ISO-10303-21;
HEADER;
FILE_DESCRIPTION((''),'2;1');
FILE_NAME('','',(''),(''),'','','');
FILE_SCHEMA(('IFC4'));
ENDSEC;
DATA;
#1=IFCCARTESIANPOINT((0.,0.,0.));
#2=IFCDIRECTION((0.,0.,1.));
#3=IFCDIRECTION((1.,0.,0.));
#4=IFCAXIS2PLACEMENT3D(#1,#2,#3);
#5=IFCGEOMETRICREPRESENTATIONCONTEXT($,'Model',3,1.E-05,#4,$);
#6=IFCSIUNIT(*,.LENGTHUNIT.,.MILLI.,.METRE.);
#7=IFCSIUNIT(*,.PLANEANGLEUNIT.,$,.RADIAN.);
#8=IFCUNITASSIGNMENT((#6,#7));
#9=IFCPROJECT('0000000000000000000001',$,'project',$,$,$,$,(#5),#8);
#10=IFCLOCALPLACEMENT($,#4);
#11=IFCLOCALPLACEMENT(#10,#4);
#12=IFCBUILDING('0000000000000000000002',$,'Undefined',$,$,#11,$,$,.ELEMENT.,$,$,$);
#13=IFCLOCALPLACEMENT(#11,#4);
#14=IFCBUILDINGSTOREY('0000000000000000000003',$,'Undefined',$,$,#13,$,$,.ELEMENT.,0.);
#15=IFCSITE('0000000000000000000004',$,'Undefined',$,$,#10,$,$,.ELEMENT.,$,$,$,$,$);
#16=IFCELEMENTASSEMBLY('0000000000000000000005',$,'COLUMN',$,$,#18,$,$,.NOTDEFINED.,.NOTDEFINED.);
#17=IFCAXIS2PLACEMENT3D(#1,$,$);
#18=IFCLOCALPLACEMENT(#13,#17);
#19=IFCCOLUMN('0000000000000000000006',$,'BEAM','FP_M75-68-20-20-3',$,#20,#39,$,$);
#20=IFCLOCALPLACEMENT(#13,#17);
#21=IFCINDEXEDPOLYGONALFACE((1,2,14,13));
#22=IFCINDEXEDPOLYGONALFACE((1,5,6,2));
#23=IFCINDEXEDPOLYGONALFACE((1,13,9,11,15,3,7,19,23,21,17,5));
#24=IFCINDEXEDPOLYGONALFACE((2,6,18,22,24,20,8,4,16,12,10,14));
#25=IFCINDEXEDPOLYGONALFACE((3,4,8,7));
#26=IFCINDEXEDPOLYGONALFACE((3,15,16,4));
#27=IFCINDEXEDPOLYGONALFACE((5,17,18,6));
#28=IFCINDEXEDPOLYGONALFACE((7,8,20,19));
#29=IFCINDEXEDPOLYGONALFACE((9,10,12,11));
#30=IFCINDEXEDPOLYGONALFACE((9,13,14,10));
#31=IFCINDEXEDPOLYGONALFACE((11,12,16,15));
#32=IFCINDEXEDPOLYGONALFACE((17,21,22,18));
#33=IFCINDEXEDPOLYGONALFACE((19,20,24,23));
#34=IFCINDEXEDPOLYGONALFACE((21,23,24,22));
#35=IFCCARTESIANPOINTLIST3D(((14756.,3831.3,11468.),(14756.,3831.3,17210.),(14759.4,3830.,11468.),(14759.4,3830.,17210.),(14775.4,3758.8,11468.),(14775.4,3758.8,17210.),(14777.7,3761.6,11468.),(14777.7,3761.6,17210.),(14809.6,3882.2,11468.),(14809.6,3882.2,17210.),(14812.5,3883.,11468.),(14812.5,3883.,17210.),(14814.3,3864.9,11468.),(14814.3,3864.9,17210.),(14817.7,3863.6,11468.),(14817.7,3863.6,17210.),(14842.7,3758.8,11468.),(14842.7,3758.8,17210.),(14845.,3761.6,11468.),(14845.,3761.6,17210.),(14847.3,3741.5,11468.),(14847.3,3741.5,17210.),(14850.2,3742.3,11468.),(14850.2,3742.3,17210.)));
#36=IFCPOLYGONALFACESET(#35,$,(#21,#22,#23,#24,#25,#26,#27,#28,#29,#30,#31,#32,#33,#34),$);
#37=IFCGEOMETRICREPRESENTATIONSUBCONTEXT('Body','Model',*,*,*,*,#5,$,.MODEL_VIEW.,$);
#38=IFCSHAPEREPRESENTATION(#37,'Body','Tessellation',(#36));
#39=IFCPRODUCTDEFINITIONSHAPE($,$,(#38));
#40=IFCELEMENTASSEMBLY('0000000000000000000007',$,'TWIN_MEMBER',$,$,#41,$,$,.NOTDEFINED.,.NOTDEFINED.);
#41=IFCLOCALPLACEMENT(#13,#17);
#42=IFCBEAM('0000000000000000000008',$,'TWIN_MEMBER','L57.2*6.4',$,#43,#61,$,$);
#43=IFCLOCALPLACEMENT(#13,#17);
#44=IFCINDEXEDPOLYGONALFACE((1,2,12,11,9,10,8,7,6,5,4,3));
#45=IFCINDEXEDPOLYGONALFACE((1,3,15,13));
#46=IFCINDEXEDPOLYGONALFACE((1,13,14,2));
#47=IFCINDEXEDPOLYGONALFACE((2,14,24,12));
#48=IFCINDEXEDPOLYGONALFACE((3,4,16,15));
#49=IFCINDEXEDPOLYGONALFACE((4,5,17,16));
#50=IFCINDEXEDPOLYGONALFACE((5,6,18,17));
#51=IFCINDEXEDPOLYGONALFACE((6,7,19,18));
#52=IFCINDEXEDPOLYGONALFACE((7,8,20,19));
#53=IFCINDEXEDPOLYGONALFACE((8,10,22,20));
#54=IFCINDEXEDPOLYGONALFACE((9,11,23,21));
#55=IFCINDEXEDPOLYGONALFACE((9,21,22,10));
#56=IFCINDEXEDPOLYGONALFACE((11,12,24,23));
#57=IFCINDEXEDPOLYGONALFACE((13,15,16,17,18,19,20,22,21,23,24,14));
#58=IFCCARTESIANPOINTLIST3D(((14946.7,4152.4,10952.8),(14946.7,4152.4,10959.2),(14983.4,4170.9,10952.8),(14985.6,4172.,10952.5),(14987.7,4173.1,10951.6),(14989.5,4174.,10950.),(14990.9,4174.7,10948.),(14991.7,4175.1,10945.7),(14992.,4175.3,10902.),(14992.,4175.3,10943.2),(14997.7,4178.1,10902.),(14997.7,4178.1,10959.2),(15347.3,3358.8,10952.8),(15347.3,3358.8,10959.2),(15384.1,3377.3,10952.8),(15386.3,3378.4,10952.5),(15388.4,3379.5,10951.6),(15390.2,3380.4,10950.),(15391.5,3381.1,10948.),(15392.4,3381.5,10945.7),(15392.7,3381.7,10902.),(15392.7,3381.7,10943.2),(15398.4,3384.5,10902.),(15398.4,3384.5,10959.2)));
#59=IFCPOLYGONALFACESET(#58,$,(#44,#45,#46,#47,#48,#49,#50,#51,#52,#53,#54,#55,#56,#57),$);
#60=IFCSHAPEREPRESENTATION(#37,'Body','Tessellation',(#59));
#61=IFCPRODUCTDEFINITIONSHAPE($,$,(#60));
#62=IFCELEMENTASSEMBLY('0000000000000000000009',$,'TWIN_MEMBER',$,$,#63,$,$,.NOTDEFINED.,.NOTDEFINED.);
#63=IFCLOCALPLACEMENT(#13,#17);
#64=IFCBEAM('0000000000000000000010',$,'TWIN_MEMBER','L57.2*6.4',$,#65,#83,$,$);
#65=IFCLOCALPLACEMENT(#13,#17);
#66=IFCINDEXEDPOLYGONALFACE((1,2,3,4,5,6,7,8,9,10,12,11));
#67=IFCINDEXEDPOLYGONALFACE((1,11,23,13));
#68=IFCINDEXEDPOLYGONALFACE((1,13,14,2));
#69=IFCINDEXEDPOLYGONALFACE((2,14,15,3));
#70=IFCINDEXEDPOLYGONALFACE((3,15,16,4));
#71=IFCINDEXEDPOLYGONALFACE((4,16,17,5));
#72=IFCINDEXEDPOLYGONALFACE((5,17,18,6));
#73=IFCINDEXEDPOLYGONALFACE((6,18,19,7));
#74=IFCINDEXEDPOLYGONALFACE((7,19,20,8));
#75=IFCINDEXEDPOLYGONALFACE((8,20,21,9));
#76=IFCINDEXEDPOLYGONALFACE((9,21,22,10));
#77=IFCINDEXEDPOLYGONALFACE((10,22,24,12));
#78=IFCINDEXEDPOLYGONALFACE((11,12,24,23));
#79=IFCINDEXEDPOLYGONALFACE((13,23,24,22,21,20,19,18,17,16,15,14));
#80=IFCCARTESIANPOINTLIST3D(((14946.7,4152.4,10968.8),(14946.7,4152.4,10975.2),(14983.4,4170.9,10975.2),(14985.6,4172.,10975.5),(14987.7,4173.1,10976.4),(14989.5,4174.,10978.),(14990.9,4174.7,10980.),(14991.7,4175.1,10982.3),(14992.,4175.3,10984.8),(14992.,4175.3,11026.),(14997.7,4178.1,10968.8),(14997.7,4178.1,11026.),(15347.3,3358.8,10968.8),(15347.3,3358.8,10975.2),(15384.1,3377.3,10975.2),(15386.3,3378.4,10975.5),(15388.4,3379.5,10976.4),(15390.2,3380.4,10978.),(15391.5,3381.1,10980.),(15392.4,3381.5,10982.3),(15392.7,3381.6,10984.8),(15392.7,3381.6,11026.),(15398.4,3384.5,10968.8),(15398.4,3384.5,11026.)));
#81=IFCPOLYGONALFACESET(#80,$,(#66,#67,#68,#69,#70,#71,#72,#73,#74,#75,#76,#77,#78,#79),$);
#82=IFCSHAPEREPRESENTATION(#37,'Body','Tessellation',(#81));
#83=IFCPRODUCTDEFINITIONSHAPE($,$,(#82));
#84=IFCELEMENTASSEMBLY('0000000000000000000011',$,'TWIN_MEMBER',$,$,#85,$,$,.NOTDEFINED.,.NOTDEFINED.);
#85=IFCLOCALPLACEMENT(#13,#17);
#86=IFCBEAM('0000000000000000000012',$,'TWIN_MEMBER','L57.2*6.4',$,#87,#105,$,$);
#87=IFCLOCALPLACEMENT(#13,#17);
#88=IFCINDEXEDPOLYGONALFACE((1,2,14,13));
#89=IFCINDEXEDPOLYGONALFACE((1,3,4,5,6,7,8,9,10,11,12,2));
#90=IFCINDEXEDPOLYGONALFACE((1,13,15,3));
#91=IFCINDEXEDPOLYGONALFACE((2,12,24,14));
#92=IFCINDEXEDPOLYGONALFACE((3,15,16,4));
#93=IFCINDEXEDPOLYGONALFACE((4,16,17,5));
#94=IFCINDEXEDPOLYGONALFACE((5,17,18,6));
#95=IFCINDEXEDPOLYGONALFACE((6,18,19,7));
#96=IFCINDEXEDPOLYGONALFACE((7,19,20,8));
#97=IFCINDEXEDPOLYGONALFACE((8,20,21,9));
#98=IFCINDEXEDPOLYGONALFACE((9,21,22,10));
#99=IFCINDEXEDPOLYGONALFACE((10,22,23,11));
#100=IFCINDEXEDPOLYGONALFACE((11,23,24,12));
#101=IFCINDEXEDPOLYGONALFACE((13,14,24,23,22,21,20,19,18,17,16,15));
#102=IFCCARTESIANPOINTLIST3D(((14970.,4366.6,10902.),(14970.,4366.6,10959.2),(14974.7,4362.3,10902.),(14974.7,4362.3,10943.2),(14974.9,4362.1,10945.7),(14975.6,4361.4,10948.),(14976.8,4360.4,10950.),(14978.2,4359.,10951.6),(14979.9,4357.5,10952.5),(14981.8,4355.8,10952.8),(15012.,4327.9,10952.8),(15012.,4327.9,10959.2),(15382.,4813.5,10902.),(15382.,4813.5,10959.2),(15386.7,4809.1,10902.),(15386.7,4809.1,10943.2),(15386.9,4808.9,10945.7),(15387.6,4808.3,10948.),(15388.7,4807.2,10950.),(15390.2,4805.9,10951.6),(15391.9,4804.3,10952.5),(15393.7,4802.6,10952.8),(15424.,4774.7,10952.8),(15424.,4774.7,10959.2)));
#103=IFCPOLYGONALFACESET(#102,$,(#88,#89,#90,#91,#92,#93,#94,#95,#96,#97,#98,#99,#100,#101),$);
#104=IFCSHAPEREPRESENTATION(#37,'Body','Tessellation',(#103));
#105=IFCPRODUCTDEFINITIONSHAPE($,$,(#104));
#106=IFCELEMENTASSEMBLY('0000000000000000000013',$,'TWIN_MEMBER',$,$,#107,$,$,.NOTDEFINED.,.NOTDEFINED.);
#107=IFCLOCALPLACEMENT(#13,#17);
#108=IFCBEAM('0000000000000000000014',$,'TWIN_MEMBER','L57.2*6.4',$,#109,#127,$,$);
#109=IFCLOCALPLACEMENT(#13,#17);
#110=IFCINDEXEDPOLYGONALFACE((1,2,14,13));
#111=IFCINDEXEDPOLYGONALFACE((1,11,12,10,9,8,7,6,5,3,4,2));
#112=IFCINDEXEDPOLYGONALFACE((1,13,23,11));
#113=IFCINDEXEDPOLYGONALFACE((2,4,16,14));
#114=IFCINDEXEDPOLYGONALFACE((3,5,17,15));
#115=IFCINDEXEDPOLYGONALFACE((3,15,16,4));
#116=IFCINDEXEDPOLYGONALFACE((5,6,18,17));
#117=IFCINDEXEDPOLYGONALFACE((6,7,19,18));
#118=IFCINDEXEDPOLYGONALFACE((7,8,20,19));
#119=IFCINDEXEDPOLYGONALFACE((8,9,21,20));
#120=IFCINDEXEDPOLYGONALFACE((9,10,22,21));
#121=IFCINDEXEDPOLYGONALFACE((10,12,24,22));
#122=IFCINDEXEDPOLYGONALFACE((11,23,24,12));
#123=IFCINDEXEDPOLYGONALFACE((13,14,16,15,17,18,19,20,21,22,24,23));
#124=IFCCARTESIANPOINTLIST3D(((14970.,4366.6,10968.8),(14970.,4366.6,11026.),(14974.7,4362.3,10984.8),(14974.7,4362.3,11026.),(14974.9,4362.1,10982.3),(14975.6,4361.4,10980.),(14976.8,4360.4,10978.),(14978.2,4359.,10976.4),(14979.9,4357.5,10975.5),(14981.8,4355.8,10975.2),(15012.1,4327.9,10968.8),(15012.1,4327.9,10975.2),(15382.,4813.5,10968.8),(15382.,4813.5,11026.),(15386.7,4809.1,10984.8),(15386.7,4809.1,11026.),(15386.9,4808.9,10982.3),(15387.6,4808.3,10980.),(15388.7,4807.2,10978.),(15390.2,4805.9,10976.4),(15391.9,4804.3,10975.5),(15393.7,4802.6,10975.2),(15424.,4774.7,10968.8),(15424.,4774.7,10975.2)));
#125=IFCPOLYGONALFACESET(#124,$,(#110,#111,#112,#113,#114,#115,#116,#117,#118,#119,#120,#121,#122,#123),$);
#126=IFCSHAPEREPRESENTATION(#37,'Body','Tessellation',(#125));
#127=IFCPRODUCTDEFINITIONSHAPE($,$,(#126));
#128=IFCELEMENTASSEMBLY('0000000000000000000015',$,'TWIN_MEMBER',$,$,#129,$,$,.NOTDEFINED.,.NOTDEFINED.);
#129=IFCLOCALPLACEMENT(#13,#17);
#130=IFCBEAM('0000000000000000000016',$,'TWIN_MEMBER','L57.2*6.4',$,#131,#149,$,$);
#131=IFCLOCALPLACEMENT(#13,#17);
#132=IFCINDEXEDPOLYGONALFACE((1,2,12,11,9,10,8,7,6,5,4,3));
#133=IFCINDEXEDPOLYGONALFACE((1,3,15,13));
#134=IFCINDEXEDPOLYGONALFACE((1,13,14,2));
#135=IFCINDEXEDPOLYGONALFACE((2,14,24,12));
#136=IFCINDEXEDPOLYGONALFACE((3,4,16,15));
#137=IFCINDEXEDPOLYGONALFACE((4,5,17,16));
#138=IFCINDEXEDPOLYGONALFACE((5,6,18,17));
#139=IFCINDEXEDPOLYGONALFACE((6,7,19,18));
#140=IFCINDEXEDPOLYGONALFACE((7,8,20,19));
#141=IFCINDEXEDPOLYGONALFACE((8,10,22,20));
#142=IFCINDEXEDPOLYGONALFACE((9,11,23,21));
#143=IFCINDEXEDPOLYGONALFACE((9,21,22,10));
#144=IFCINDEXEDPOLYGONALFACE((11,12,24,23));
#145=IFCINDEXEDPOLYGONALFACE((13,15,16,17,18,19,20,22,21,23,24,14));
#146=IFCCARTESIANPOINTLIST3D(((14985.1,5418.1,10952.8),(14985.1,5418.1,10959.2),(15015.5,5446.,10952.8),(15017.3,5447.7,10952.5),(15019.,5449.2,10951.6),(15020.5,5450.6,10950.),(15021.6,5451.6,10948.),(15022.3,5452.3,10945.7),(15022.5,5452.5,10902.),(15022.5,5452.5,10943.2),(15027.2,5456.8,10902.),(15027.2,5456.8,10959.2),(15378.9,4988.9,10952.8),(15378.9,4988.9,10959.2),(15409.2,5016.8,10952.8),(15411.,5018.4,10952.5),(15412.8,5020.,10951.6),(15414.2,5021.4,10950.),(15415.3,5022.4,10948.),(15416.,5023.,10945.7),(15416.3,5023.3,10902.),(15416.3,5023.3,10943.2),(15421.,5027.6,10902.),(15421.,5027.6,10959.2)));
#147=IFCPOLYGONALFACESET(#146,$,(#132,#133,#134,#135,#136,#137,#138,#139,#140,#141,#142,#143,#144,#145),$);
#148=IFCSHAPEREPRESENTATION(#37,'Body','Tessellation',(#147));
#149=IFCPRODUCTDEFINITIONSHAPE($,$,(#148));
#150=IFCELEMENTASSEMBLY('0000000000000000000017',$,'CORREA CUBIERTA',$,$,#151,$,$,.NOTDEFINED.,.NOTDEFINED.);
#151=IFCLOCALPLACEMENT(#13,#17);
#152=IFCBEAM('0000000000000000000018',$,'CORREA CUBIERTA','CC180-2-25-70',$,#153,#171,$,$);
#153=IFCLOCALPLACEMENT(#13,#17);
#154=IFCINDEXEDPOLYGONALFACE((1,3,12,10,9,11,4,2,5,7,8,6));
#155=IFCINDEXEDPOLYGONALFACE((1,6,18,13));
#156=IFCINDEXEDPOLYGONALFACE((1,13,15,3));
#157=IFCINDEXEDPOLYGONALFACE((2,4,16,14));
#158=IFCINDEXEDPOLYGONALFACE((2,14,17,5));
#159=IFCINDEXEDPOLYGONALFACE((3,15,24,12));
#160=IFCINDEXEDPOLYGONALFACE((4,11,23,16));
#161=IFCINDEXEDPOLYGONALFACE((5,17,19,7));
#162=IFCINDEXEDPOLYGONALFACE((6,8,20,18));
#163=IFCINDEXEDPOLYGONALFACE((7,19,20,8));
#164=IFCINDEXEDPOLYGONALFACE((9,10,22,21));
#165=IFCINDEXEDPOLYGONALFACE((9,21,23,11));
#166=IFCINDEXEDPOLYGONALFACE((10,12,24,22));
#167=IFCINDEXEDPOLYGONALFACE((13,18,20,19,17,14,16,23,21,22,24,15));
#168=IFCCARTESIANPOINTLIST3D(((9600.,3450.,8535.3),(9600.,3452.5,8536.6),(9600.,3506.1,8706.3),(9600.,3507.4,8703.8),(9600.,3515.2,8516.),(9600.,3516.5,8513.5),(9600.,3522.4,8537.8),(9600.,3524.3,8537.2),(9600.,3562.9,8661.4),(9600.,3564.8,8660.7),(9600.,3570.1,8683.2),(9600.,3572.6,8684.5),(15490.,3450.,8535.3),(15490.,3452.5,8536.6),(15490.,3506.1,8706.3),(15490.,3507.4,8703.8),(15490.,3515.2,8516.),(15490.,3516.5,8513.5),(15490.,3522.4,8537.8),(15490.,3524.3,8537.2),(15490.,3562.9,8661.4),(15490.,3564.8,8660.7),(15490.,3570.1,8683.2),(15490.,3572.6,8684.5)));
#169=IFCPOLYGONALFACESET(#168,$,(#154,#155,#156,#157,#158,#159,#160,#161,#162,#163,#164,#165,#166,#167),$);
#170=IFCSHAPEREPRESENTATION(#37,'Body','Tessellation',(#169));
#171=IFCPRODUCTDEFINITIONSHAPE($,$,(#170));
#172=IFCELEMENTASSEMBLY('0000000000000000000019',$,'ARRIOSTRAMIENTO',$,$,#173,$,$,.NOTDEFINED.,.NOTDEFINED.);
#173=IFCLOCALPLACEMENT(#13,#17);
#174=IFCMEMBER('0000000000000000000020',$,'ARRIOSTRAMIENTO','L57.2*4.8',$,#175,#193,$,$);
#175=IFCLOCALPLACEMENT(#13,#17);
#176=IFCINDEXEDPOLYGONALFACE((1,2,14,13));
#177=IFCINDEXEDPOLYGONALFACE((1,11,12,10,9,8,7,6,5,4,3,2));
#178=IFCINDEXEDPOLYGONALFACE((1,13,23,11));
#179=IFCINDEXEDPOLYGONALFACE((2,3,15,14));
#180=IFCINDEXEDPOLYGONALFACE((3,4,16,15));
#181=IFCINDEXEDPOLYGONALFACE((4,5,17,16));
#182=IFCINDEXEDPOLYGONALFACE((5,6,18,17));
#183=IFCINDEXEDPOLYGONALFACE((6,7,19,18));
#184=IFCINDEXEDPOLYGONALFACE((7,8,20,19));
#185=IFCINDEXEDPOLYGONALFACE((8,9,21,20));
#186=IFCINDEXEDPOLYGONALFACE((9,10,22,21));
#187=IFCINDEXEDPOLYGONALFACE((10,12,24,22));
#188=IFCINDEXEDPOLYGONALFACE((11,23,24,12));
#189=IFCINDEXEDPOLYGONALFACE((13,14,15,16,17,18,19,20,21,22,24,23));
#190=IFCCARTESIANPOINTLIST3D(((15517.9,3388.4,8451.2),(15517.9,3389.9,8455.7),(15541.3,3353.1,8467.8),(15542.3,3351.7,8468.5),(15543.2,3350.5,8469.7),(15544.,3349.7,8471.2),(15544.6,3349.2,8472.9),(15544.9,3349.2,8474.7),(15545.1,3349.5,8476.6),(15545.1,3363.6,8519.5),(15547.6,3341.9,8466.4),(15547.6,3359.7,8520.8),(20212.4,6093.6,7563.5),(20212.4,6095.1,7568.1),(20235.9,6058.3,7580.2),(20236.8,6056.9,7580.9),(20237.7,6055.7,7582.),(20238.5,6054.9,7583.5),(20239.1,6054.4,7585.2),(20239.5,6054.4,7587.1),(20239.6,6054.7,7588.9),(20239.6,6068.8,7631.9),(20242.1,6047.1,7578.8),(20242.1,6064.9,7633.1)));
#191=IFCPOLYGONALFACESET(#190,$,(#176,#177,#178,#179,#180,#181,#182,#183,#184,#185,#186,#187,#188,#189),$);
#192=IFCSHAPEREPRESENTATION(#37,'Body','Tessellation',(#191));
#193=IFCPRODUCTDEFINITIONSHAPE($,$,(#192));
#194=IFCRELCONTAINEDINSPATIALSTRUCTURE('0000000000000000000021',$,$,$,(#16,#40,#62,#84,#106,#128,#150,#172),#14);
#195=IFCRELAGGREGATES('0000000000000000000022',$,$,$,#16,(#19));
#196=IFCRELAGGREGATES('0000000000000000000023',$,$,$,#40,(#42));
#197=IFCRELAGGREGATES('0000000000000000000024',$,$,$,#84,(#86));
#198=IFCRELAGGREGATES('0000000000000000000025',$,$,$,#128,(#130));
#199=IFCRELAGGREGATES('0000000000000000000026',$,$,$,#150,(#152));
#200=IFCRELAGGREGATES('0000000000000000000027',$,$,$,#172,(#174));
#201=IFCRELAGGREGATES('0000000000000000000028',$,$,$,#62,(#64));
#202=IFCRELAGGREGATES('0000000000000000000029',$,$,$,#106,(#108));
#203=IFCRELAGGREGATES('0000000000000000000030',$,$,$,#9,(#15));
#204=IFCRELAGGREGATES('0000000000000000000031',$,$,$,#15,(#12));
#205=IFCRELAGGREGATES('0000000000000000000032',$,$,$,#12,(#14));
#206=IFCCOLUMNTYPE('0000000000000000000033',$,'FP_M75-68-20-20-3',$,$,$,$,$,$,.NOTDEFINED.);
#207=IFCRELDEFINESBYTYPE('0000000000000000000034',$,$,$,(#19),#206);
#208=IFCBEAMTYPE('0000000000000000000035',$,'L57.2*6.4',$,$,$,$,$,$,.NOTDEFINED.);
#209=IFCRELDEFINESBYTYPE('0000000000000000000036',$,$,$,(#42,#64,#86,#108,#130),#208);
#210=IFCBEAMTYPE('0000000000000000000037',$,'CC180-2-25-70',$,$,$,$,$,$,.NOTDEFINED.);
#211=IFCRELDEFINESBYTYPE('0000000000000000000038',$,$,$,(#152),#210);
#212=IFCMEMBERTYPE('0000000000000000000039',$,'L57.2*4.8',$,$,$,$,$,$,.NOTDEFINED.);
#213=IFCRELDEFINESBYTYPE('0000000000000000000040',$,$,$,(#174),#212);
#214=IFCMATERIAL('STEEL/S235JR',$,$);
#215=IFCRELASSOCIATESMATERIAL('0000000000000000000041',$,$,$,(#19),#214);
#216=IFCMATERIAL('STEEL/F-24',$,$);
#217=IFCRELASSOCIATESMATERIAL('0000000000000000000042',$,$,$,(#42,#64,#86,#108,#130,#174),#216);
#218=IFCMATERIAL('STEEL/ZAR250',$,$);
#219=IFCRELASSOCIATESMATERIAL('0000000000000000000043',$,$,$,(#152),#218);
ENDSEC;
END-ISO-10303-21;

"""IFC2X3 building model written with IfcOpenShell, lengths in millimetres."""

from ifc_helpers import new_model, si_unit, frame, origin_with_axes, origin_2d_with_axis, place, context, subcontext, project, spatial, polyline, l_section, c_section, outline, extrude, clip, halfspace, material, type_object, element, aggregate, save


model = new_model("IFC2X3")

# Units and contexts
model_context = context("Model", 3, precision=1e-05, world=origin_with_axes())
body_context = subcontext(model_context, "Body", "Model", "MODEL_VIEW")
ifc_project = project(units=[si_unit("LENGTHUNIT", "METRE", prefix="MILLI"), si_unit("PLANEANGLEUNIT", "RADIAN")], contexts=[model_context])

# Site, building, storey
site_placement = place(None, origin_with_axes())
site = spatial("IfcSite", under=ifc_project, at=site_placement, Name="Undefined", CompositionType="ELEMENT")
building_placement = place(site_placement, origin_with_axes())
building = spatial("IfcBuilding", under=site, at=building_placement, Name="Undefined", CompositionType="ELEMENT")
storey_placement = place(building_placement, origin_with_axes())
storey = spatial("IfcBuildingStorey", under=building, at=storey_placement, Name="Undefined", CompositionType="ELEMENT", Elevation=0.0)

# Element assembly, column
assembly_1_placement = place(storey_placement, origin_with_axes())
assembly_1 = element("IfcElementAssembly", 1, at=assembly_1_placement, inside=storey, Name="COLUMN", AssemblyPlace="NOTDEFINED", PredefinedType="NOTDEFINED")
ifc_material_1 = material(Name="STEEL/S235JR")
column_type = type_object("IfcColumnType", Name="FP_M75-68-20-20-3", PredefinedType="NOTDEFINED")
column_placement = place(assembly_1_placement, frame((14798.5, 3803.8, 11468.0), z_axis=(0.0, 0.0, 1.0), x_axis=(0.258819, -0.965926, 0.0)))
column = element("IfcColumn", 2, at=column_placement, type_object=column_type, material=ifc_material_1, Name="BEAM", Description="FP_M75-68-20-20-3", context=body_context, shape_type="SweptSolid", body=[
    extrude(outline(polyline([(31.0, 54.9), (31.0, 72.8), (34.0, 72.8), (34.0, 52.8), (-31.0, 35.4), (-31.0, -35.4), (34.0, -52.8), (34.0, -72.8), (31.0, -72.8), (31.0, -54.9), (-34.0, -37.5), (-34.0, 37.5), (31.0, 54.9)])), frame((0.0, 0.0, 5742.0), z_axis=(0.0, 0.0, -1.0), x_axis=(0.0, 1.0, 0.0)), (0.0, 0.0, 1.0), 5742.0),
])
aggregate(assembly_1, [column])

# Element assemblies, beams
assembly_2_placement = place(storey_placement, origin_with_axes())
assembly_2 = element("IfcElementAssembly", 3, at=assembly_2_placement, inside=storey, Name="TWIN_MEMBER", AssemblyPlace="NOTDEFINED", PredefinedType="NOTDEFINED")
ifc_material_2 = material(Name="STEEL/F-24")
beam_type_1 = type_object("IfcBeamType", Name="L57.2*6.4", PredefinedType="NOTDEFINED")
beam_1_placement = place(assembly_2_placement, frame((15372.9, 3371.6, 10930.6), z_axis=(0.0, 0.0, -1.0), x_axis=(-0.450691, 0.89268, 0.0)))
beam_1 = element("IfcBeam", 4, at=beam_1_placement, type_object=beam_type_1, material=ifc_material_2, Name="TWIN_MEMBER", Description="L57.2*6.4", context=body_context, shape_type="SweptSolid", body=[
    extrude(l_section(Depth=57.2, Width=57.2, Thickness=6.4, FilletRadius=9.6, at=origin_2d_with_axis()), frame((889.0, 0.0, 0.0), z_axis=(-1.0, 0.0, 0.0), x_axis=(0.0, -1.0, 0.0)), (0.0, 0.0, 1.0), 889.0),
])
aggregate(assembly_2, [beam_1])
assembly_3_placement = place(storey_placement, origin_with_axes())
assembly_3 = element("IfcElementAssembly", 5, at=assembly_3_placement, inside=storey, Name="TWIN_MEMBER", AssemblyPlace="NOTDEFINED", PredefinedType="NOTDEFINED")
beam_2_placement = place(assembly_3_placement, frame((14972.2, 4165.2, 10997.4), z_axis=(0.0, 0.0, 1.0), x_axis=(0.450691, -0.89268, 0.0)))
beam_2 = element("IfcBeam", 6, at=beam_2_placement, type_object=beam_type_1, material=ifc_material_2, Name="TWIN_MEMBER", Description="L57.2*6.4", context=body_context, shape_type="SweptSolid", body=[
    extrude(l_section(Depth=57.2, Width=57.2, Thickness=6.4, FilletRadius=9.6, at=origin_2d_with_axis()), frame((889.0, 0.0, 0.0), z_axis=(-1.0, 0.0, 0.0), x_axis=(0.0, -1.0, 0.0)), (0.0, 0.0, 1.0), 889.0),
])
assembly_4_placement = place(storey_placement, origin_with_axes())
assembly_4 = element("IfcElementAssembly", 7, at=assembly_4_placement, inside=storey, Name="TWIN_MEMBER", AssemblyPlace="NOTDEFINED", PredefinedType="NOTDEFINED")
beam_3_placement = place(assembly_4_placement, frame((15403.0, 4794.1, 10930.6), z_axis=(0.0, 0.0, -1.0), x_axis=(-0.677842, -0.735208, 0.0)))
beam_3 = element("IfcBeam", 8, at=beam_3_placement, type_object=beam_type_1, material=ifc_material_2, Name="TWIN_MEMBER", Description="L57.2*6.4", context=body_context, shape_type="SweptSolid", body=[
    extrude(l_section(Depth=57.2, Width=57.2, Thickness=6.4, FilletRadius=9.6, at=origin_2d_with_axis()), frame((607.8, 0.0, 0.0), z_axis=(-1.0, 0.0, 0.0), x_axis=(0.0, -1.0, 0.0)), (0.0, 0.0, 1.0), 607.8),
])
aggregate(assembly_4, [beam_3])
assembly_5_placement = place(storey_placement, origin_with_axes())
assembly_5 = element("IfcElementAssembly", 9, at=assembly_5_placement, inside=storey, Name="TWIN_MEMBER", AssemblyPlace="NOTDEFINED", PredefinedType="NOTDEFINED")
beam_4_placement = place(assembly_5_placement, frame((14991.0, 4347.3, 10997.4), z_axis=(0.0, 0.0, 1.0), x_axis=(0.677842, 0.735208, 0.0)))
beam_4 = element("IfcBeam", 10, at=beam_4_placement, type_object=beam_type_1, material=ifc_material_2, Name="TWIN_MEMBER", Description="L57.2*6.4", context=body_context, shape_type="SweptSolid", body=[
    extrude(l_section(Depth=57.2, Width=57.2, Thickness=6.4, FilletRadius=9.6, at=origin_2d_with_axis()), frame((607.8, 0.0, 0.0), z_axis=(-1.0, 0.0, 0.0), x_axis=(0.0, -1.0, 0.0)), (0.0, 0.0, 1.0), 607.8),
])
assembly_6_placement = place(storey_placement, origin_with_axes())
assembly_6 = element("IfcElementAssembly", 11, at=assembly_6_placement, inside=storey, Name="TWIN_MEMBER", AssemblyPlace="NOTDEFINED", PredefinedType="NOTDEFINED")
beam_5_placement = place(assembly_6_placement, frame((15399.9, 5008.2, 10930.6), z_axis=(0.0, 0.0, -1.0), x_axis=(-0.67601, 0.736893, 0.0)))
beam_5 = element("IfcBeam", 12, at=beam_5_placement, type_object=beam_type_1, material=ifc_material_2, Name="TWIN_MEMBER", Description="L57.2*6.4", context=body_context, shape_type="SweptSolid", body=[
    extrude(l_section(Depth=57.2, Width=57.2, Thickness=6.4, FilletRadius=9.6, at=origin_2d_with_axis()), frame((582.5, 0.0, 0.0), z_axis=(-1.0, 0.0, 0.0), x_axis=(0.0, -1.0, 0.0)), (0.0, 0.0, 1.0), 582.5),
])
aggregate(assembly_6, [beam_5])
assembly_7_placement = place(storey_placement, origin_with_axes())
assembly_7 = element("IfcElementAssembly", 13, at=assembly_7_placement, inside=storey, Name="CORREA CUBIERTA", AssemblyPlace="NOTDEFINED", PredefinedType="NOTDEFINED")
ifc_material_3 = material(Name="STEEL/ZAR250")
beam_type_2 = type_object("IfcBeamType", Name="CC180-2-25-70", PredefinedType="NOTDEFINED")
beam_6_placement = place(assembly_7_placement, frame((15490.0, 3511.3, 8609.9), z_axis=(0.0, 0.311771, 0.950157), x_axis=(-1.0, 0.0, 0.0)))
beam_6 = element("IfcBeam", 14, at=beam_6_placement, type_object=beam_type_2, material=ifc_material_3, Name="CORREA CUBIERTA", Description="CC180-2-25-70", context=body_context, shape_type="SweptSolid", body=[
    extrude(c_section(Depth=180.0, Width=70.0, WallThickness=2.0, Girth=25.0, at=origin_2d_with_axis()), frame((5890.0, 0.0, 0.0), z_axis=(-1.0, 0.0, 0.0), x_axis=(0.0, -1.0, 0.0)), (0.0, 0.0, 1.0), 5890.0),
])
aggregate(assembly_7, [beam_6])

# Element assembly, member
assembly_8_placement = place(storey_placement, origin_with_axes())
assembly_8 = element("IfcElementAssembly", 15, at=assembly_8_placement, inside=storey, Name="ARRIOSTRAMIENTO", AssemblyPlace="NOTDEFINED", PredefinedType="NOTDEFINED")
member_type = type_object("IfcMemberType", Name="L57.2*4.8", PredefinedType="NOTDEFINED")
member_placement = place(assembly_8_placement, frame((15495.0, 3352.3, 8493.1), z_axis=(-0.518558, 0.812425, -0.266577), x_axis=(0.855043, 0.492712, -0.161671)))
member = element("IfcMember", 16, at=member_placement, type_object=member_type, material=ifc_material_2, Name="ARRIOSTRAMIENTO", Description="L57.2*4.8", context=body_context, shape_type="Clipping", body=[
    clip(clip(extrude(l_section(Depth=57.2, Width=57.2, Thickness=4.8, FilletRadius=7.2, at=origin_2d_with_axis()), frame((5595.4, 0.0, 0.0), z_axis=(-1.0, 0.0, 0.0), x_axis=(0.0, -1.0, 0.0)), (0.0, 0.0, 1.0), 5612.1), halfspace(frame((5534.5, 38.1, 0.0), z_axis=(-1.0, 0.0, 0.0), x_axis=(0.0, 0.000039, 1.0)), True)), halfspace(frame((44.1, 28.6, 0.0), z_axis=(1.0, 0.0, 0.0), x_axis=(0.0, -0.000039, -1.0)), True)),
])
aggregate(assembly_8, [member])

aggregate(assembly_3, [beam_2])
aggregate(assembly_5, [beam_4])

save(model, "model.ifc")
